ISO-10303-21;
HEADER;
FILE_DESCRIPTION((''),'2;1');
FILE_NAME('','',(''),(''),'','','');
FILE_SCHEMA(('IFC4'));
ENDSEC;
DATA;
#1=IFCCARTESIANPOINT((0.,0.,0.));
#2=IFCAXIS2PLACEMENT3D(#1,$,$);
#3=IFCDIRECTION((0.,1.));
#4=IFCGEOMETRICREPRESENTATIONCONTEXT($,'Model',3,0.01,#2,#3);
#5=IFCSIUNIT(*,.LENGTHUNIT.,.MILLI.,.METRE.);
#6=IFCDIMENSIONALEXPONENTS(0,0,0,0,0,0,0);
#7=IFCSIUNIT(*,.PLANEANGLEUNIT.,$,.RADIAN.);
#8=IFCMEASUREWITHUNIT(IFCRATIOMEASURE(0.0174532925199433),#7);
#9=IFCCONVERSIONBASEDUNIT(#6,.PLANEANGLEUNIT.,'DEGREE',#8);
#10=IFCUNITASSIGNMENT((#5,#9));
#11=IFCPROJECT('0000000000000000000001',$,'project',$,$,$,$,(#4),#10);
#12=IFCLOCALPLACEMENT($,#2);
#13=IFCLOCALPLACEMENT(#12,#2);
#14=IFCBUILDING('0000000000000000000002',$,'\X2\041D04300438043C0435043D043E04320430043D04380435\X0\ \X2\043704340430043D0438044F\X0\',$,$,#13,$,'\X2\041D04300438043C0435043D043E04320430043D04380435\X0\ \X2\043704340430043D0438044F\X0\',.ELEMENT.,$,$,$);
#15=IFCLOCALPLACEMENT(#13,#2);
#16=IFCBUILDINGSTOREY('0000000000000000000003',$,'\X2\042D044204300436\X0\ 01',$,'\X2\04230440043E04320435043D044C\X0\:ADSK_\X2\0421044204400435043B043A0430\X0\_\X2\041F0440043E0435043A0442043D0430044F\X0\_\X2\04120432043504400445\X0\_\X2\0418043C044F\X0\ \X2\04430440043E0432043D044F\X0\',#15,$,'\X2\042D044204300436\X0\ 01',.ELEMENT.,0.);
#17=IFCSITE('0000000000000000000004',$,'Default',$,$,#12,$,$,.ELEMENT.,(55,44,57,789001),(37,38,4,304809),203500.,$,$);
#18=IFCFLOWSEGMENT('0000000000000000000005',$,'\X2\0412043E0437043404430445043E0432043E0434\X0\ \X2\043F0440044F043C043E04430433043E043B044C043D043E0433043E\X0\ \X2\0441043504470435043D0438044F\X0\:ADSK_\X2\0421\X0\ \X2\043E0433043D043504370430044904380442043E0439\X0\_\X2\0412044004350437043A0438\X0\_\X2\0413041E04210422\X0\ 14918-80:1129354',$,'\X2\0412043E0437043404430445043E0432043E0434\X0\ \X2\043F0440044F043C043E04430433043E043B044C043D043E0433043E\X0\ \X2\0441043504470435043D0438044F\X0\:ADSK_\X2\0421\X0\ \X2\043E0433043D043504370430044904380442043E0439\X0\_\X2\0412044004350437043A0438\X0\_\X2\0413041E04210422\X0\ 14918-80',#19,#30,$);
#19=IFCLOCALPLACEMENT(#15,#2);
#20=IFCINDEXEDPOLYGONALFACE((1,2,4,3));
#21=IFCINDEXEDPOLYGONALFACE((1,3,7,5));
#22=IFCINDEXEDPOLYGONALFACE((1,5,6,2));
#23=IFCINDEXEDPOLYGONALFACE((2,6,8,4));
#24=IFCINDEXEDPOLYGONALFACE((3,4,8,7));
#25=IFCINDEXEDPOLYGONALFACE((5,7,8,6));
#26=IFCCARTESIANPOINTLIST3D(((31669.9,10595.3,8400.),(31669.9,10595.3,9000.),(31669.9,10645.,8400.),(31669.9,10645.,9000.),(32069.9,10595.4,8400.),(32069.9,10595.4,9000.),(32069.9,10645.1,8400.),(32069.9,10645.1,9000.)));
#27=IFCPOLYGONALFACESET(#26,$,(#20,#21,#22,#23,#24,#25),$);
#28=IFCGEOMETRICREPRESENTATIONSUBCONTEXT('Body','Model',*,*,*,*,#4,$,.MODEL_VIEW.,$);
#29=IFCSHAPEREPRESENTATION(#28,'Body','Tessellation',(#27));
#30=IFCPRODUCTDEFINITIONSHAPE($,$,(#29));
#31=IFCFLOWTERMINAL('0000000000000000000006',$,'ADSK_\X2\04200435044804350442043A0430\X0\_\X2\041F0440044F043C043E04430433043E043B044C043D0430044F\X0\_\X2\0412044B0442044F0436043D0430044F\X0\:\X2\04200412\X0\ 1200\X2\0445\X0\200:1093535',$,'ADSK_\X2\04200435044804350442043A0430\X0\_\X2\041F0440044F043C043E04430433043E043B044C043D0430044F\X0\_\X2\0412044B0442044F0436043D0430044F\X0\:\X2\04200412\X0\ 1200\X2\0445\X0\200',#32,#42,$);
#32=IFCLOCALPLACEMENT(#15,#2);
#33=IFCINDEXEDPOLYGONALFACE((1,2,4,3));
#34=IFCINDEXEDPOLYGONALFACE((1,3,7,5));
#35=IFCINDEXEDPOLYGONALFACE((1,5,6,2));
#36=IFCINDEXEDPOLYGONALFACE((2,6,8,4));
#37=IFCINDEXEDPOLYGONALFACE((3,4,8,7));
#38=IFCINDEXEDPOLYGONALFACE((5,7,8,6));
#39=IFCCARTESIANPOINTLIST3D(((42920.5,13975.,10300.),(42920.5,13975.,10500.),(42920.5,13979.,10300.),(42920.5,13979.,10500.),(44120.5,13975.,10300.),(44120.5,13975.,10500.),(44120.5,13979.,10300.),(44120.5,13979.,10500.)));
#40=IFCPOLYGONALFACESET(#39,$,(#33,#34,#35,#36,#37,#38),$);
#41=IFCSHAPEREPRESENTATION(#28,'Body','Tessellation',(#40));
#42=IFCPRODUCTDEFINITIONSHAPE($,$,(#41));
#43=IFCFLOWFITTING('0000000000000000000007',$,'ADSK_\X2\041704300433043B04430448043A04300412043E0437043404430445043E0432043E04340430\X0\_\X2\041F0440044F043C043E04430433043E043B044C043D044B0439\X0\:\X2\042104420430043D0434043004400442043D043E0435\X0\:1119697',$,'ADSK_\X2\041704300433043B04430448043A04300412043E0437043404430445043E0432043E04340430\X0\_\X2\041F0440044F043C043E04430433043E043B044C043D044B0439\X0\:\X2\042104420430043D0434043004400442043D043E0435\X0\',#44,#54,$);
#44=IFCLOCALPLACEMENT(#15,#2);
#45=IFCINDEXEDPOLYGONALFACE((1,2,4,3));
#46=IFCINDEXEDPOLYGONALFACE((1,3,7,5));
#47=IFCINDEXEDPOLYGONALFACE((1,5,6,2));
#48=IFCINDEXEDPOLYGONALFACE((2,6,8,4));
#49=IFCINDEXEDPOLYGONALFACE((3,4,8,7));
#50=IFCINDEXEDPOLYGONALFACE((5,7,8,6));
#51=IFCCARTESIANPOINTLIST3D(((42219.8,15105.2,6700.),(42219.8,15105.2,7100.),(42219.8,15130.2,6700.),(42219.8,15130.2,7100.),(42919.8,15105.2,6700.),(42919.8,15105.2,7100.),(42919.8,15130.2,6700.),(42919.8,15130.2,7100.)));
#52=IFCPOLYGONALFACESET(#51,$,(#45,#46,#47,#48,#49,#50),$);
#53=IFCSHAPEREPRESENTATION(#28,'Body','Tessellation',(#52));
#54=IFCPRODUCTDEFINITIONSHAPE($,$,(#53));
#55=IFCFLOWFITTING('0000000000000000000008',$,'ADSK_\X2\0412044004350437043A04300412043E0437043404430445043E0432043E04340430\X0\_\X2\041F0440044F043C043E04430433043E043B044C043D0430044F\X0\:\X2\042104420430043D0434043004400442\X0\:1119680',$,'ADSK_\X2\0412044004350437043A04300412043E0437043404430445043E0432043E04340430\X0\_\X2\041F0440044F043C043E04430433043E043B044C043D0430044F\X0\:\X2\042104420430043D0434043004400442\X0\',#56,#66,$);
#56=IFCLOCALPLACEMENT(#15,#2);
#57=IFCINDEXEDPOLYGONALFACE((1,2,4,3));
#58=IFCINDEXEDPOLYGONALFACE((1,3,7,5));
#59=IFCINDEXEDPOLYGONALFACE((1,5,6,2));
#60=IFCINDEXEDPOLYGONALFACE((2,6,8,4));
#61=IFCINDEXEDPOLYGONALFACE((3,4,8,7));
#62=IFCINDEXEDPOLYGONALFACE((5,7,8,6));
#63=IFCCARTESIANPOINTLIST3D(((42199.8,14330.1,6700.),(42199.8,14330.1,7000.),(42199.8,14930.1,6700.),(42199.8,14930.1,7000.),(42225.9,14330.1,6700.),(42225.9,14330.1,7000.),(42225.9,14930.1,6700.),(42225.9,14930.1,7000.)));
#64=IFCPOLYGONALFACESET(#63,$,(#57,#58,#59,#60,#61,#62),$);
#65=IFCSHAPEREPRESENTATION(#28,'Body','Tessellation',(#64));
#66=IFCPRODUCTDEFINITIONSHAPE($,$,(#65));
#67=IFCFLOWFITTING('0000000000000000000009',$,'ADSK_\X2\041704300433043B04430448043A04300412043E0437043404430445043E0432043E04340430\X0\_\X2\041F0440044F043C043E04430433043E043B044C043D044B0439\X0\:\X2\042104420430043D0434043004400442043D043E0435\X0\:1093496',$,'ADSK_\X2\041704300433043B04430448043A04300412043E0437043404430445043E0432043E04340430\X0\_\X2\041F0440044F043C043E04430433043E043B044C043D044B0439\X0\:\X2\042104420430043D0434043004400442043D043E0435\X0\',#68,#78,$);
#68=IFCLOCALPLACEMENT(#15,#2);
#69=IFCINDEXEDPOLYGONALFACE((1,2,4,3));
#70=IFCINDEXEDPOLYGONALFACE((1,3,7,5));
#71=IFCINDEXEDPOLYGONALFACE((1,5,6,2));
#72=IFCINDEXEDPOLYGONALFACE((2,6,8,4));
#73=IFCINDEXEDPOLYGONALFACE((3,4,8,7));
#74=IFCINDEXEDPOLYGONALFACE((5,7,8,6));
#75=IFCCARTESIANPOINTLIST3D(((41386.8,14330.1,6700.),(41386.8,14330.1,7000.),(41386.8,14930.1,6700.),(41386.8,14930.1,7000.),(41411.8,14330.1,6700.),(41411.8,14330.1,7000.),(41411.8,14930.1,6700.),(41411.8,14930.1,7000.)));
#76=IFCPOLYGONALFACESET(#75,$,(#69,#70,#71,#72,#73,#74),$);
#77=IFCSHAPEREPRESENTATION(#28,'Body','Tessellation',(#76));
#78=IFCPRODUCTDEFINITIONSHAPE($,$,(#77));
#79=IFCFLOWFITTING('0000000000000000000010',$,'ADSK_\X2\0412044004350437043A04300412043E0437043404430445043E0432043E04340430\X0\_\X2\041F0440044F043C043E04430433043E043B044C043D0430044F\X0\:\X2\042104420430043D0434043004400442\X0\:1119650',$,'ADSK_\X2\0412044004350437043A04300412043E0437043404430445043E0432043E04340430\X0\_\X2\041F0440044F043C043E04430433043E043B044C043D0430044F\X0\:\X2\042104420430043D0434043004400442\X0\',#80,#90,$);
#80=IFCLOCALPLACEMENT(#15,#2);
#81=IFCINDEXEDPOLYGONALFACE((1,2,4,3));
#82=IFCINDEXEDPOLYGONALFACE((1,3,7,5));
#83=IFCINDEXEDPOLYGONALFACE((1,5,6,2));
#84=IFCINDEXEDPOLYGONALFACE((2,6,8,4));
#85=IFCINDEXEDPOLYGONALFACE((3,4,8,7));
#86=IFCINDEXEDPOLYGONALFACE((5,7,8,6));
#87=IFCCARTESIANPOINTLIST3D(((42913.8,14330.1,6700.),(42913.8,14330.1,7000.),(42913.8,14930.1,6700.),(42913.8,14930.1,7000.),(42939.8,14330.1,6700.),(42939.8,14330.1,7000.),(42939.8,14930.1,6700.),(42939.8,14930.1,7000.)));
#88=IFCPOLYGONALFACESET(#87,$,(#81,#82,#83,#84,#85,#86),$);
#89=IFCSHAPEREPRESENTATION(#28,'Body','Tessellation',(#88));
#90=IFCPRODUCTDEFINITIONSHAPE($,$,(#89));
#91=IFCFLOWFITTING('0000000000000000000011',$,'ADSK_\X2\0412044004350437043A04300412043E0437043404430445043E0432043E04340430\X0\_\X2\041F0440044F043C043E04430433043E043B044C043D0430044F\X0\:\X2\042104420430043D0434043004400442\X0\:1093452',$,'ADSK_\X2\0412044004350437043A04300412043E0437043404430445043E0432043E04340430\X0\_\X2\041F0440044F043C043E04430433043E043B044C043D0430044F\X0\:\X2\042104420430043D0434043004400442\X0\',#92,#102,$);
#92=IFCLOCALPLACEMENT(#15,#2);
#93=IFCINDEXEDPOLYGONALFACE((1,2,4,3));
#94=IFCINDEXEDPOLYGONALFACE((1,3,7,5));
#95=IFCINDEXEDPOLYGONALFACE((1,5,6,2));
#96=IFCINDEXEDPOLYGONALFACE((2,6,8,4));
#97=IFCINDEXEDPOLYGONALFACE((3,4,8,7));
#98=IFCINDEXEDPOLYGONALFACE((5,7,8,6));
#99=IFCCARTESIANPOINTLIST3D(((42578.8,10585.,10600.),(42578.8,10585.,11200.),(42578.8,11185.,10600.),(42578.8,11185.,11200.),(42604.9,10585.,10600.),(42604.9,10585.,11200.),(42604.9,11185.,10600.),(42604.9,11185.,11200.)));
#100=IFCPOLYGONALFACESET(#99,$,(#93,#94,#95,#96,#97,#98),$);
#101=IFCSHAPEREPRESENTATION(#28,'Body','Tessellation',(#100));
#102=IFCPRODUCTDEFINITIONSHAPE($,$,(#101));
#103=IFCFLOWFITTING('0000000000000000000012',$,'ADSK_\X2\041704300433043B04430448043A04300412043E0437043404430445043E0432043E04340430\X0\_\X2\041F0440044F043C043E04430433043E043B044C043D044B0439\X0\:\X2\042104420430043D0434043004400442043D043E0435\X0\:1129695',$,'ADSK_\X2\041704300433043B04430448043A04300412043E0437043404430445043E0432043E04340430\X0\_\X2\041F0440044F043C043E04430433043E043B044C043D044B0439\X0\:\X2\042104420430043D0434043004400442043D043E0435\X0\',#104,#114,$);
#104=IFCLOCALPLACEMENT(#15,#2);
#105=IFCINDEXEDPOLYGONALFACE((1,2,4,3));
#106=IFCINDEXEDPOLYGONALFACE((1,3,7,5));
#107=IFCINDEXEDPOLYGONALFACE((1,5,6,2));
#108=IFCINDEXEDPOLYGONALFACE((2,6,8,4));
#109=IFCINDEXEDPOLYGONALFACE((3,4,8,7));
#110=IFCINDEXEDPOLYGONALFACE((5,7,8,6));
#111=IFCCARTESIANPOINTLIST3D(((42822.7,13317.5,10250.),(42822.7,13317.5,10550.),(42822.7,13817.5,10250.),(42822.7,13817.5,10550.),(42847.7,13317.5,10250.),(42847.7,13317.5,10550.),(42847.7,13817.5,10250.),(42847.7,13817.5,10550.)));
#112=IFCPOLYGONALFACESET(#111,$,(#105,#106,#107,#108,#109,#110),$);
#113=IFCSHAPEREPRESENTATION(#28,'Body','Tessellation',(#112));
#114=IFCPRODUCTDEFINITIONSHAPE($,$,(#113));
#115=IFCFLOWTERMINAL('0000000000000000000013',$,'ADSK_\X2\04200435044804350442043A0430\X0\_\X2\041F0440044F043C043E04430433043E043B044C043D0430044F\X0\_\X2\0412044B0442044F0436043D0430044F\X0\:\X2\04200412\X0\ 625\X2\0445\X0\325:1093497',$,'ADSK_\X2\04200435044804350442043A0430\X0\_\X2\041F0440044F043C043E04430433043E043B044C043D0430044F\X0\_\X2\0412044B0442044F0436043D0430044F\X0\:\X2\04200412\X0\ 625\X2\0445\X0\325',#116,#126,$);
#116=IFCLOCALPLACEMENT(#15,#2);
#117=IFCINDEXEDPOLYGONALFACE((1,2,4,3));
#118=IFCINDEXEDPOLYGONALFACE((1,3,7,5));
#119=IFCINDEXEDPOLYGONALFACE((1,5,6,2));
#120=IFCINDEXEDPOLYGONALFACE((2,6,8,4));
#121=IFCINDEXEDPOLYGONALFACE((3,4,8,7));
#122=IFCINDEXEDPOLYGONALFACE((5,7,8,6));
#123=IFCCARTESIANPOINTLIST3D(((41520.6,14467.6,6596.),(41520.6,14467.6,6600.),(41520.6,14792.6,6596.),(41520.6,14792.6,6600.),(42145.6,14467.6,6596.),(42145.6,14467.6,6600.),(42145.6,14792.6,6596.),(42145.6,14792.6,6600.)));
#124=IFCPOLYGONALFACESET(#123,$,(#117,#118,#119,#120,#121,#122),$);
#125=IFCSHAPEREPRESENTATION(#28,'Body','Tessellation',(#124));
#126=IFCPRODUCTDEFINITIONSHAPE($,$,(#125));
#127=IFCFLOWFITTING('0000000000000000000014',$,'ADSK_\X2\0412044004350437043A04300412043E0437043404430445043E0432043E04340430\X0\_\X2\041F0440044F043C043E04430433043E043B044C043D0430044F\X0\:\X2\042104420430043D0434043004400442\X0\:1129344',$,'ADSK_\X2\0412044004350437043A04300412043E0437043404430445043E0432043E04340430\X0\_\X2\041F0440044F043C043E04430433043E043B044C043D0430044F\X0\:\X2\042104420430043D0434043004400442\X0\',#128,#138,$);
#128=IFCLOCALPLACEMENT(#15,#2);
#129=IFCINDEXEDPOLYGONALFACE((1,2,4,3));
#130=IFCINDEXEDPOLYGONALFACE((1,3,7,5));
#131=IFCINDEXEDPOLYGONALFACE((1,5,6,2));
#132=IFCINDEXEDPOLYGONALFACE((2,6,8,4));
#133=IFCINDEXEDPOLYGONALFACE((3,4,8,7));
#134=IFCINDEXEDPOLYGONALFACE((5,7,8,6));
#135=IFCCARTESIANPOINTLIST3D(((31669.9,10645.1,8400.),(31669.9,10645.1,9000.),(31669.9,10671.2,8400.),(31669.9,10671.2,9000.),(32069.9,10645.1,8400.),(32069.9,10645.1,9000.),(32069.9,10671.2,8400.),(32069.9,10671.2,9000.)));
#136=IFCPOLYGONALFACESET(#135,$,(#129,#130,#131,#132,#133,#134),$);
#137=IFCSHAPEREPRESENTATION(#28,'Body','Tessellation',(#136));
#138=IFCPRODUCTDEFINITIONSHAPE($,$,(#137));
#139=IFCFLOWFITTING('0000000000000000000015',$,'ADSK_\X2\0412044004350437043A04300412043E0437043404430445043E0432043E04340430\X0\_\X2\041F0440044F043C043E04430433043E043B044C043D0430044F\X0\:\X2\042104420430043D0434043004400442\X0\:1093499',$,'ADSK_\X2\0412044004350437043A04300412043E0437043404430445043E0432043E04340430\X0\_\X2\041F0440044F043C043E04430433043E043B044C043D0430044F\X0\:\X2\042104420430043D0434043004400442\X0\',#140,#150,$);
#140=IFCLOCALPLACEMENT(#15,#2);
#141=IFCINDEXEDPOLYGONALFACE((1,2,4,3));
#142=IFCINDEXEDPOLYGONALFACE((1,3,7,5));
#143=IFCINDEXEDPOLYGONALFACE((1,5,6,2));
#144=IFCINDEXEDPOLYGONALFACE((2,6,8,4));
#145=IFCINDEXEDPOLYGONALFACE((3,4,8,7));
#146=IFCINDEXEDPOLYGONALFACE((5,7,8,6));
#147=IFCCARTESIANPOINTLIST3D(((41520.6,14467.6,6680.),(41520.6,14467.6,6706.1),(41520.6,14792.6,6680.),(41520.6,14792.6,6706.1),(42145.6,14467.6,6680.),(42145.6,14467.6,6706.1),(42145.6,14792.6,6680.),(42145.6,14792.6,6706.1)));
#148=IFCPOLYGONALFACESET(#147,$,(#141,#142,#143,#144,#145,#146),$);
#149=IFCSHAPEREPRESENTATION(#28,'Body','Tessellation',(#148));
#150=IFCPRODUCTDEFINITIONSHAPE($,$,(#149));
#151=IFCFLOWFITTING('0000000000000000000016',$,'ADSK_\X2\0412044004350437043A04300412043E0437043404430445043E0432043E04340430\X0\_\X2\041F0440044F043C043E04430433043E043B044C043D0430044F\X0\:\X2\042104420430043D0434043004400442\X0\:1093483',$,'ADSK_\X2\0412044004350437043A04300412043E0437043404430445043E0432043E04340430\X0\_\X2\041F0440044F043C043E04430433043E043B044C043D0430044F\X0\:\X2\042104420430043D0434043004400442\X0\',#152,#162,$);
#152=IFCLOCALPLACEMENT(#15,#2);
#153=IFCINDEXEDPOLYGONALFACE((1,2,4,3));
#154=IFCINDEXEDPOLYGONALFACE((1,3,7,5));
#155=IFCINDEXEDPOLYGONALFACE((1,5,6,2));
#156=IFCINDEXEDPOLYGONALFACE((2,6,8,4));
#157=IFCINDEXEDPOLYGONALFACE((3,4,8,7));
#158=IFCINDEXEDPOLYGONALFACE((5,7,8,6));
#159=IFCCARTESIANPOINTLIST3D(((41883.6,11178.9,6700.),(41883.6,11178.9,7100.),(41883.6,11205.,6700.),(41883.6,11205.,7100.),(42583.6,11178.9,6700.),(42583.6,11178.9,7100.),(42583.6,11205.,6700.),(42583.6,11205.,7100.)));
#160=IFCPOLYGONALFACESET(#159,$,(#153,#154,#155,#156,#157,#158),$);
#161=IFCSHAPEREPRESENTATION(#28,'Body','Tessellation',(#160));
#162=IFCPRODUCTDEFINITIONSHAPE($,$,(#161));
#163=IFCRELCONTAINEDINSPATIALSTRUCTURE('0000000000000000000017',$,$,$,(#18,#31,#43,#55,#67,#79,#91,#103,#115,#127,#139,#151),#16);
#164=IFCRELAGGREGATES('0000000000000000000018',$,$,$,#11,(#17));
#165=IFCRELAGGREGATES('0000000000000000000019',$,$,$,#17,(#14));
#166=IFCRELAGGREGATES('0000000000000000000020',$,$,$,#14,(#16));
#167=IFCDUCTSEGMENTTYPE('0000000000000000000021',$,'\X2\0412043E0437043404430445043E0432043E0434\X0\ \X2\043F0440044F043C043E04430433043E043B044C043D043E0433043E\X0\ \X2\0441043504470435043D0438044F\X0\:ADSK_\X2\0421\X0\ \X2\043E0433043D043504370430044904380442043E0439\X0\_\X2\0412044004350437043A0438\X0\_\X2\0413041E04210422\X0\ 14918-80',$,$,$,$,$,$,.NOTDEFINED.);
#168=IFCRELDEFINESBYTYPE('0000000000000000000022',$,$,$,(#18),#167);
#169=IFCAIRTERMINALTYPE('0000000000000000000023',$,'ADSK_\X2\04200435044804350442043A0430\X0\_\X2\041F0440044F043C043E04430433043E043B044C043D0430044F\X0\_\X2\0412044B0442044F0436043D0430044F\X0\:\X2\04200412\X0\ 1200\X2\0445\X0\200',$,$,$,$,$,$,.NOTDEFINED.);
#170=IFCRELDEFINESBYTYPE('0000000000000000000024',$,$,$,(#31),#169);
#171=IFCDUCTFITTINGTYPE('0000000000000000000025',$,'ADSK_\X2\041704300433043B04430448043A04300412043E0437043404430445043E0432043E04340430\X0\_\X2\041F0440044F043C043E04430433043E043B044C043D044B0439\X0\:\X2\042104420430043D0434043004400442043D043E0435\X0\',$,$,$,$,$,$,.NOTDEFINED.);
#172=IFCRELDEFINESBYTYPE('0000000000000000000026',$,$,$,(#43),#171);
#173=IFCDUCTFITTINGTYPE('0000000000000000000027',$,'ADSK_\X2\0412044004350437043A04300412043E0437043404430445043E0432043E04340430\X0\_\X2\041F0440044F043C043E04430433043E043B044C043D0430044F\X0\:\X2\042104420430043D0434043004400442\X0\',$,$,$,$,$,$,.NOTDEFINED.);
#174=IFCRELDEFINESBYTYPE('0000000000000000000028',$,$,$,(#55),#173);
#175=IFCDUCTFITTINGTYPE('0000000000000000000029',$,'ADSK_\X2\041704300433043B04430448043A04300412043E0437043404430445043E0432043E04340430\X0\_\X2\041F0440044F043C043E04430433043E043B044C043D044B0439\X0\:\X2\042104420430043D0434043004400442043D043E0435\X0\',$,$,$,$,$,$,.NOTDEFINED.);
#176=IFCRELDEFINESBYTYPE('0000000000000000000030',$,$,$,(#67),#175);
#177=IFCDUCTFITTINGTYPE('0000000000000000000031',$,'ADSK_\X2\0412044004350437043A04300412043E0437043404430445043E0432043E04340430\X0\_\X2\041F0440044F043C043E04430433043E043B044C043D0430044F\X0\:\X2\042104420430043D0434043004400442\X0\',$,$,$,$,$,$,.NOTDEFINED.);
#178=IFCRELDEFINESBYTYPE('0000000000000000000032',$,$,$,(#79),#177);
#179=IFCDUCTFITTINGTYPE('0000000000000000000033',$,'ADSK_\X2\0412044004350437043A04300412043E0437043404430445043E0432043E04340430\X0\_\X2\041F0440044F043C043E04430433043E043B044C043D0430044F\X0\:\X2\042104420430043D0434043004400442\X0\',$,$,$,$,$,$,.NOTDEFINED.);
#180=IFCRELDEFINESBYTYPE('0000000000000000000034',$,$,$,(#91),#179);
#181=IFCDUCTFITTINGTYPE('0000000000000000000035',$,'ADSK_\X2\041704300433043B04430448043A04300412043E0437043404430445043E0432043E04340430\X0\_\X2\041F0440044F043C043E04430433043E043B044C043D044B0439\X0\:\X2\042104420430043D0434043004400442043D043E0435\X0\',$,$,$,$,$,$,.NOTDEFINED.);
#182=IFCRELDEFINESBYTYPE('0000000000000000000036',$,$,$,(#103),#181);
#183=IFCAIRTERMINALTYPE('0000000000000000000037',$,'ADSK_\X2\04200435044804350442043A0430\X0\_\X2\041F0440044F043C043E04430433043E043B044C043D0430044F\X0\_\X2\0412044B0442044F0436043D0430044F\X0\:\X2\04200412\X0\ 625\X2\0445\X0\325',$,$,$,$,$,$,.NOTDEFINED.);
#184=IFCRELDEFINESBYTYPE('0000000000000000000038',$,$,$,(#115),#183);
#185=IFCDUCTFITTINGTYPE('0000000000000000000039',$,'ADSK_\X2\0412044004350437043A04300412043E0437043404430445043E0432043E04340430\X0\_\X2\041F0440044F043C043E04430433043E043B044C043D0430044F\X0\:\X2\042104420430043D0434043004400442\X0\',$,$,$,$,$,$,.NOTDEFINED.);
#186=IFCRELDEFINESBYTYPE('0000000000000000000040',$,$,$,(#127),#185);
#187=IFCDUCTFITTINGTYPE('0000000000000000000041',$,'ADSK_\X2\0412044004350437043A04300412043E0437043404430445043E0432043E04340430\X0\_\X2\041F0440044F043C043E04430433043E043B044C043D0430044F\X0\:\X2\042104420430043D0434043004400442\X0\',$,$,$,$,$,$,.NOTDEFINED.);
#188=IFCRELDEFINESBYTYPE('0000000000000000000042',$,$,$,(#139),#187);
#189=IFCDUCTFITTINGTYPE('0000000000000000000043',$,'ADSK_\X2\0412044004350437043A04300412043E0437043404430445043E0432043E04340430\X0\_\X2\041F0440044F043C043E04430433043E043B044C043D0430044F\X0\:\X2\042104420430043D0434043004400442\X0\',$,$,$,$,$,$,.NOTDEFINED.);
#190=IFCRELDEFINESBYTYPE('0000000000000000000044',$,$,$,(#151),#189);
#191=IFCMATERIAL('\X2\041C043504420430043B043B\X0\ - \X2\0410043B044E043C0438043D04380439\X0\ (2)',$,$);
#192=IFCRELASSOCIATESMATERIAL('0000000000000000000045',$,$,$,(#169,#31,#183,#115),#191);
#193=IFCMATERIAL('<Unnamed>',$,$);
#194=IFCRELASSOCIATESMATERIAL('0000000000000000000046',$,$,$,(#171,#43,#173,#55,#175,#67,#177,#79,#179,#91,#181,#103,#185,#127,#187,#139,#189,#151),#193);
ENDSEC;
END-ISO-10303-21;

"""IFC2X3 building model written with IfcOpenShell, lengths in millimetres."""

from ifc_helpers import new_model, entity, si_unit, converted_unit, direction, frame, frame_2d, origin, origin_2d_with_axis, place, context, subcontext, project, spatial, rectangle, extrude, source, transform, mapped, material, type_object, type_shapes, element, save


model = new_model("IFC2X3")

# Units and contexts
model_context = context("Model", 3, precision=0.01, world=origin(), true_north=direction((0.0, 1.0)))
body_context = subcontext(model_context, "Body", "Model", "MODEL_VIEW")
ifc_project = project(units=[si_unit("LENGTHUNIT", "METRE", prefix="MILLI"), converted_unit("PLANEANGLEUNIT", "DEGREE", entity("IfcRatioMeasure", 0.0174532925199433), si_unit("PLANEANGLEUNIT", "RADIAN"), dimensions=[0, 0, 0, 0, 0, 0, 0])], contexts=[model_context])

# Site, building, storey
site_placement = place(None, frame((0.0, 0.0, 0.0)))
site = spatial("IfcSite", under=ifc_project, at=site_placement, Name="Default", CompositionType="ELEMENT", RefLatitude=(55, 44, 57, 789001), RefLongitude=(37, 38, 4, 304809), RefElevation=203500.0)
building_placement = place(site_placement, origin())
building = spatial("IfcBuilding", under=site, at=building_placement, Name="Наименование здания", LongName="Наименование здания", CompositionType="ELEMENT")
storey_placement = place(building_placement, origin())
storey = spatial("IfcBuildingStorey", under=building, at=storey_placement, Name="Этаж 01", ObjectType="Уровень:ADSK_Стрелка_Проектная_Вверх_Имя уровня", LongName="Этаж 01", CompositionType="ELEMENT", Elevation=0.0)

# Flow segment
duct_segment_type = type_object("IfcDuctSegmentType", Name="Воздуховод прямоугольного сечения:ADSK_С огнезащитой_Врезки_ГОСТ 14918-80", PredefinedType="NOTDEFINED")
flow_segment_1_placement = place(storey_placement, frame((31669.9, 10595.3, 8400.0)))
element("IfcFlowSegment", 1, at=flow_segment_1_placement, inside=storey, type_object=duct_segment_type, Name="Воздуховод прямоугольного сечения:ADSK_С огнезащитой_Врезки_ГОСТ 14918-80:1129354", ObjectType="Воздуховод прямоугольного сечения:ADSK_С огнезащитой_Врезки_ГОСТ 14918-80", context=body_context, shape_type="SweptSolid", body=[
    extrude(rectangle(XDim=49.7, YDim=400.0, at=frame_2d((0.0, 0.0), x_axis=(1.0, 0.0))), frame((200.0, 24.9, 0.0), z_axis=(0.0, 0.0, 1.0), x_axis=(-0.000236, 1.0, 0.0)), (0.0, 0.0, 1.0), 600.0),
])

# Flow terminal
ifc_material_1 = material(Name="Металл - Алюминий (2)")
air_terminal_type_1 = type_object("IfcAirTerminalType", Name="ADSK_Решетка_Прямоугольная_Вытяжная:РВ 1200х200", PredefinedType="NOTDEFINED", material=ifc_material_1)
shared_shape_1 = source(origin(), body_context, "Body", "SweptSolid", [
    extrude(rectangle(XDim=4.0, YDim=1200.0, at=origin_2d_with_axis()), frame((0.0, -2.0, -100.0), z_axis=(0.0, 0.0, 1.0), x_axis=(0.0, 1.0, 0.0)), (0.0, 0.0, 1.0), 200.0),
])
type_shapes(air_terminal_type_1, [shared_shape_1])
flow_terminal_1_placement = place(storey_placement, frame((43520.5, 13975.0, 10400.0), z_axis=(0.0, 0.0, 1.0), x_axis=(-1.0, 0.0, 0.0)))
element("IfcFlowTerminal", 2, at=flow_terminal_1_placement, inside=storey, type_object=air_terminal_type_1, material=ifc_material_1, Name="ADSK_Решетка_Прямоугольная_Вытяжная:РВ 1200х200:1093535", ObjectType="ADSK_Решетка_Прямоугольная_Вытяжная:РВ 1200х200", context=body_context, shape_type="MappedRepresentation", body=[
    mapped(shared_shape_1, transform((0.0, 0.0, 0.0), scale=1.0)),
])

# Flow fittings
ifc_material_2 = material(Name="<Unnamed>")
duct_fitting_type_1 = type_object("IfcDuctFittingType", Name="ADSK_ЗаглушкаВоздуховода_Прямоугольный:Стандартное", PredefinedType="NOTDEFINED", material=ifc_material_2)
shared_shape_2 = source(origin(), body_context, "Body", "SweptSolid", [
    extrude(rectangle(XDim=25.0, YDim=700.0, at=frame_2d((0.0, 0.0), x_axis=(1.0, 0.0))), frame((12.5, 0.0, -200.0)), (0.0, 0.0, 1.0), 400.0),
])
type_shapes(duct_fitting_type_1, [shared_shape_2])
flow_fitting_1_placement = place(storey_placement, frame((42569.8, 15105.2, 6900.0), z_axis=(0.0, 0.0, 1.0), x_axis=(0.0, 1.0, 0.0)))
element("IfcFlowFitting", 3, at=flow_fitting_1_placement, inside=storey, type_object=duct_fitting_type_1, material=ifc_material_2, Name="ADSK_ЗаглушкаВоздуховода_Прямоугольный:Стандартное:1119697", ObjectType="ADSK_ЗаглушкаВоздуховода_Прямоугольный:Стандартное", context=body_context, shape_type="MappedRepresentation", body=[
    mapped(shared_shape_2, transform((0.0, 0.0, 0.0), scale=1.0)),
])
duct_fitting_type_2 = type_object("IfcDuctFittingType", Name="ADSK_ВрезкаВоздуховода_Прямоугольная:Стандарт", PredefinedType="NOTDEFINED", material=ifc_material_2)
shared_shape_3 = source(origin(), body_context, "Body", "SweptSolid", [
    extrude(rectangle(XDim=26.1, YDim=600.0, at=frame_2d((0.0, 0.0), x_axis=(1.0, 0.0))), frame((7.0, 0.0, -150.0)), (0.0, 0.0, 1.0), 300.0),
])
type_shapes(duct_fitting_type_2, [shared_shape_3])
flow_fitting_2_placement = place(storey_placement, frame((42219.8, 14630.1, 6850.0), z_axis=(0.0, 0.0, -1.0), x_axis=(-1.0, 0.0, 0.0)))
element("IfcFlowFitting", 4, at=flow_fitting_2_placement, inside=storey, type_object=duct_fitting_type_2, material=ifc_material_2, Name="ADSK_ВрезкаВоздуховода_Прямоугольная:Стандарт:1119680", ObjectType="ADSK_ВрезкаВоздуховода_Прямоугольная:Стандарт", context=body_context, shape_type="MappedRepresentation", body=[
    mapped(shared_shape_3, transform((0.0, 0.0, 0.0), scale=1.0)),
])
duct_fitting_type_3 = type_object("IfcDuctFittingType", Name="ADSK_ЗаглушкаВоздуховода_Прямоугольный:Стандартное", PredefinedType="NOTDEFINED", material=ifc_material_2)
shared_shape_4 = source(origin(), body_context, "Body", "SweptSolid", [
    extrude(rectangle(XDim=25.0, YDim=600.0, at=frame_2d((0.0, 0.0), x_axis=(1.0, 0.0))), frame((12.5, 0.0, -150.0)), (0.0, 0.0, 1.0), 300.0),
])
type_shapes(duct_fitting_type_3, [shared_shape_4])
flow_fitting_3_placement = place(storey_placement, frame((41411.8, 14630.1, 6850.0), z_axis=(0.0, 0.0, 1.0), x_axis=(-1.0, 0.0, 0.0)))
element("IfcFlowFitting", 5, at=flow_fitting_3_placement, inside=storey, type_object=duct_fitting_type_3, material=ifc_material_2, Name="ADSK_ЗаглушкаВоздуховода_Прямоугольный:Стандартное:1093496", ObjectType="ADSK_ЗаглушкаВоздуховода_Прямоугольный:Стандартное", context=body_context, shape_type="MappedRepresentation", body=[
    mapped(shared_shape_4, transform((0.0, 0.0, 0.0), scale=1.0)),
])
duct_fitting_type_4 = type_object("IfcDuctFittingType", Name="ADSK_ВрезкаВоздуховода_Прямоугольная:Стандарт", PredefinedType="NOTDEFINED", material=ifc_material_2)
shared_shape_5 = source(origin(), body_context, "Body", "SweptSolid", [
    extrude(rectangle(XDim=600.0, YDim=26.1, at=origin_2d_with_axis()), frame((7.0, 0.0, -150.0), z_axis=(0.0, 0.0, 1.0), x_axis=(0.0, -1.0, 0.0)), (0.0, 0.0, 1.0), 300.0),
])
type_shapes(duct_fitting_type_4, [shared_shape_5])
flow_fitting_4_placement = place(storey_placement, frame((42919.8, 14630.1, 6850.0), z_axis=(0.0, 0.0, -1.0), x_axis=(1.0, 0.0, 0.0)))
element("IfcFlowFitting", 6, at=flow_fitting_4_placement, inside=storey, type_object=duct_fitting_type_4, material=ifc_material_2, Name="ADSK_ВрезкаВоздуховода_Прямоугольная:Стандарт:1119650", ObjectType="ADSK_ВрезкаВоздуховода_Прямоугольная:Стандарт", context=body_context, shape_type="MappedRepresentation", body=[
    mapped(shared_shape_5, transform((0.0, 0.0, 0.0), scale=1.0)),
])
duct_fitting_type_5 = type_object("IfcDuctFittingType", Name="ADSK_ВрезкаВоздуховода_Прямоугольная:Стандарт", PredefinedType="NOTDEFINED", material=ifc_material_2)
shared_shape_6 = source(origin(), body_context, "Body", "SweptSolid", [
    extrude(rectangle(XDim=600.0, YDim=26.1, at=origin_2d_with_axis()), frame((7.0, 0.0, -300.0), z_axis=(0.0, 0.0, 1.0), x_axis=(0.0, -1.0, 0.0)), (0.0, 0.0, 1.0), 600.0),
])
type_shapes(duct_fitting_type_5, [shared_shape_6])
flow_fitting_5_placement = place(storey_placement, frame((42584.9, 10885.0, 10900.0), z_axis=(0.0, -1.0, 0.0), x_axis=(1.0, 0.0, 0.0)))
element("IfcFlowFitting", 7, at=flow_fitting_5_placement, inside=storey, type_object=duct_fitting_type_5, material=ifc_material_2, Name="ADSK_ВрезкаВоздуховода_Прямоугольная:Стандарт:1093452", ObjectType="ADSK_ВрезкаВоздуховода_Прямоугольная:Стандарт", context=body_context, shape_type="MappedRepresentation", body=[
    mapped(shared_shape_6, transform((0.0, 0.0, 0.0), scale=1.0)),
])
duct_fitting_type_6 = type_object("IfcDuctFittingType", Name="ADSK_ЗаглушкаВоздуховода_Прямоугольный:Стандартное", PredefinedType="NOTDEFINED", material=ifc_material_2)
shared_shape_7 = source(origin(), body_context, "Body", "SweptSolid", [
    extrude(rectangle(XDim=25.0, YDim=500.0, at=frame_2d((0.0, 0.0), x_axis=(1.0, 0.0))), frame((12.5, 0.0, -150.0)), (0.0, 0.0, 1.0), 300.0),
])
type_shapes(duct_fitting_type_6, [shared_shape_7])
flow_fitting_6_placement = place(storey_placement, frame((42847.7, 13567.5, 10400.0), z_axis=(0.0, 0.0, 1.0), x_axis=(-1.0, 0.0, 0.0)))
element("IfcFlowFitting", 8, at=flow_fitting_6_placement, inside=storey, type_object=duct_fitting_type_6, material=ifc_material_2, Name="ADSK_ЗаглушкаВоздуховода_Прямоугольный:Стандартное:1129695", ObjectType="ADSK_ЗаглушкаВоздуховода_Прямоугольный:Стандартное", context=body_context, shape_type="MappedRepresentation", body=[
    mapped(shared_shape_7, transform((0.0, 0.0, 0.0), scale=1.0)),
])

# Flow terminal
air_terminal_type_2 = type_object("IfcAirTerminalType", Name="ADSK_Решетка_Прямоугольная_Вытяжная:РВ 625х325", PredefinedType="NOTDEFINED", material=ifc_material_1)
shared_shape_8 = source(origin(), body_context, "Body", "SweptSolid", [
    extrude(rectangle(XDim=4.0, YDim=625.0, at=origin_2d_with_axis()), frame((0.0, -2.0, -162.5), z_axis=(0.0, 0.0, 1.0), x_axis=(0.0, 1.0, 0.0)), (0.0, 0.0, 1.0), 325.0),
])
type_shapes(air_terminal_type_2, [shared_shape_8])
flow_terminal_2_placement = place(storey_placement, frame((41833.1, 14630.1, 6600.0), z_axis=(0.0, 1.0, 0.0), x_axis=(-1.0, 0.0, 0.0)))
element("IfcFlowTerminal", 9, at=flow_terminal_2_placement, inside=storey, type_object=air_terminal_type_2, material=ifc_material_1, Name="ADSK_Решетка_Прямоугольная_Вытяжная:РВ 625х325:1093497", ObjectType="ADSK_Решетка_Прямоугольная_Вытяжная:РВ 625х325", context=body_context, shape_type="MappedRepresentation", body=[
    mapped(shared_shape_8, transform((0.0, 0.0, 0.0), scale=1.0)),
])

# Flow fittings
duct_fitting_type_7 = type_object("IfcDuctFittingType", Name="ADSK_ВрезкаВоздуховода_Прямоугольная:Стандарт", PredefinedType="NOTDEFINED", material=ifc_material_2)
shared_shape_9 = source(origin(), body_context, "Body", "SweptSolid", [
    extrude(rectangle(XDim=600.0, YDim=26.1, at=origin_2d_with_axis()), frame((7.0, 0.0, -200.0), z_axis=(0.0, 0.0, 1.0), x_axis=(0.0, -1.0, 0.0)), (0.0, 0.0, 1.0), 400.0),
])
type_shapes(duct_fitting_type_7, [shared_shape_9])
flow_fitting_7_placement = place(storey_placement, frame((31869.9, 10665.1, 8700.0), z_axis=(-1.0, 0.0, 0.0), x_axis=(0.0, -1.0, 0.0)))
element("IfcFlowFitting", 10, at=flow_fitting_7_placement, inside=storey, type_object=duct_fitting_type_7, material=ifc_material_2, Name="ADSK_ВрезкаВоздуховода_Прямоугольная:Стандарт:1129344", ObjectType="ADSK_ВрезкаВоздуховода_Прямоугольная:Стандарт", context=body_context, shape_type="MappedRepresentation", body=[
    mapped(shared_shape_9, transform((0.0, 0.0, 0.0), scale=1.0)),
])
duct_fitting_type_8 = type_object("IfcDuctFittingType", Name="ADSK_ВрезкаВоздуховода_Прямоугольная:Стандарт", PredefinedType="NOTDEFINED", material=ifc_material_2)
shared_shape_10 = source(origin(), body_context, "Body", "SweptSolid", [
    extrude(rectangle(XDim=26.1, YDim=625.0, at=frame_2d((0.0, 0.0), x_axis=(1.0, 0.0))), frame((7.0, 0.0, -162.5)), (0.0, 0.0, 1.0), 325.0),
])
type_shapes(duct_fitting_type_8, [shared_shape_10])
flow_fitting_8_placement = place(storey_placement, frame((41833.1, 14630.1, 6700.0), z_axis=(0.0, -1.0, 0.0), x_axis=(0.0, 0.0, -1.0)))
element("IfcFlowFitting", 11, at=flow_fitting_8_placement, inside=storey, type_object=duct_fitting_type_8, material=ifc_material_2, Name="ADSK_ВрезкаВоздуховода_Прямоугольная:Стандарт:1093499", ObjectType="ADSK_ВрезкаВоздуховода_Прямоугольная:Стандарт", context=body_context, shape_type="MappedRepresentation", body=[
    mapped(shared_shape_10, transform((0.0, 0.0, 0.0), scale=1.0)),
])
duct_fitting_type_9 = type_object("IfcDuctFittingType", Name="ADSK_ВрезкаВоздуховода_Прямоугольная:Стандарт", PredefinedType="NOTDEFINED", material=ifc_material_2)
shared_shape_11 = source(origin(), body_context, "Body", "SweptSolid", [
    extrude(rectangle(XDim=400.0, YDim=26.1, at=origin_2d_with_axis()), frame((7.0, 0.0, -350.0), z_axis=(0.0, 0.0, 1.0), x_axis=(0.0, -1.0, 0.0)), (0.0, 0.0, 1.0), 700.0),
])
type_shapes(duct_fitting_type_9, [shared_shape_11])
flow_fitting_9_placement = place(storey_placement, frame((42233.6, 11185.0, 6900.0), z_axis=(1.0, 0.0, 0.0), x_axis=(0.0, 1.0, 0.0)))
element("IfcFlowFitting", 12, at=flow_fitting_9_placement, inside=storey, type_object=duct_fitting_type_9, material=ifc_material_2, Name="ADSK_ВрезкаВоздуховода_Прямоугольная:Стандарт:1093483", ObjectType="ADSK_ВрезкаВоздуховода_Прямоугольная:Стандарт", context=body_context, shape_type="MappedRepresentation", body=[
    mapped(shared_shape_11, transform((0.0, 0.0, 0.0), scale=1.0)),
])

save(model, "model.ifc")
